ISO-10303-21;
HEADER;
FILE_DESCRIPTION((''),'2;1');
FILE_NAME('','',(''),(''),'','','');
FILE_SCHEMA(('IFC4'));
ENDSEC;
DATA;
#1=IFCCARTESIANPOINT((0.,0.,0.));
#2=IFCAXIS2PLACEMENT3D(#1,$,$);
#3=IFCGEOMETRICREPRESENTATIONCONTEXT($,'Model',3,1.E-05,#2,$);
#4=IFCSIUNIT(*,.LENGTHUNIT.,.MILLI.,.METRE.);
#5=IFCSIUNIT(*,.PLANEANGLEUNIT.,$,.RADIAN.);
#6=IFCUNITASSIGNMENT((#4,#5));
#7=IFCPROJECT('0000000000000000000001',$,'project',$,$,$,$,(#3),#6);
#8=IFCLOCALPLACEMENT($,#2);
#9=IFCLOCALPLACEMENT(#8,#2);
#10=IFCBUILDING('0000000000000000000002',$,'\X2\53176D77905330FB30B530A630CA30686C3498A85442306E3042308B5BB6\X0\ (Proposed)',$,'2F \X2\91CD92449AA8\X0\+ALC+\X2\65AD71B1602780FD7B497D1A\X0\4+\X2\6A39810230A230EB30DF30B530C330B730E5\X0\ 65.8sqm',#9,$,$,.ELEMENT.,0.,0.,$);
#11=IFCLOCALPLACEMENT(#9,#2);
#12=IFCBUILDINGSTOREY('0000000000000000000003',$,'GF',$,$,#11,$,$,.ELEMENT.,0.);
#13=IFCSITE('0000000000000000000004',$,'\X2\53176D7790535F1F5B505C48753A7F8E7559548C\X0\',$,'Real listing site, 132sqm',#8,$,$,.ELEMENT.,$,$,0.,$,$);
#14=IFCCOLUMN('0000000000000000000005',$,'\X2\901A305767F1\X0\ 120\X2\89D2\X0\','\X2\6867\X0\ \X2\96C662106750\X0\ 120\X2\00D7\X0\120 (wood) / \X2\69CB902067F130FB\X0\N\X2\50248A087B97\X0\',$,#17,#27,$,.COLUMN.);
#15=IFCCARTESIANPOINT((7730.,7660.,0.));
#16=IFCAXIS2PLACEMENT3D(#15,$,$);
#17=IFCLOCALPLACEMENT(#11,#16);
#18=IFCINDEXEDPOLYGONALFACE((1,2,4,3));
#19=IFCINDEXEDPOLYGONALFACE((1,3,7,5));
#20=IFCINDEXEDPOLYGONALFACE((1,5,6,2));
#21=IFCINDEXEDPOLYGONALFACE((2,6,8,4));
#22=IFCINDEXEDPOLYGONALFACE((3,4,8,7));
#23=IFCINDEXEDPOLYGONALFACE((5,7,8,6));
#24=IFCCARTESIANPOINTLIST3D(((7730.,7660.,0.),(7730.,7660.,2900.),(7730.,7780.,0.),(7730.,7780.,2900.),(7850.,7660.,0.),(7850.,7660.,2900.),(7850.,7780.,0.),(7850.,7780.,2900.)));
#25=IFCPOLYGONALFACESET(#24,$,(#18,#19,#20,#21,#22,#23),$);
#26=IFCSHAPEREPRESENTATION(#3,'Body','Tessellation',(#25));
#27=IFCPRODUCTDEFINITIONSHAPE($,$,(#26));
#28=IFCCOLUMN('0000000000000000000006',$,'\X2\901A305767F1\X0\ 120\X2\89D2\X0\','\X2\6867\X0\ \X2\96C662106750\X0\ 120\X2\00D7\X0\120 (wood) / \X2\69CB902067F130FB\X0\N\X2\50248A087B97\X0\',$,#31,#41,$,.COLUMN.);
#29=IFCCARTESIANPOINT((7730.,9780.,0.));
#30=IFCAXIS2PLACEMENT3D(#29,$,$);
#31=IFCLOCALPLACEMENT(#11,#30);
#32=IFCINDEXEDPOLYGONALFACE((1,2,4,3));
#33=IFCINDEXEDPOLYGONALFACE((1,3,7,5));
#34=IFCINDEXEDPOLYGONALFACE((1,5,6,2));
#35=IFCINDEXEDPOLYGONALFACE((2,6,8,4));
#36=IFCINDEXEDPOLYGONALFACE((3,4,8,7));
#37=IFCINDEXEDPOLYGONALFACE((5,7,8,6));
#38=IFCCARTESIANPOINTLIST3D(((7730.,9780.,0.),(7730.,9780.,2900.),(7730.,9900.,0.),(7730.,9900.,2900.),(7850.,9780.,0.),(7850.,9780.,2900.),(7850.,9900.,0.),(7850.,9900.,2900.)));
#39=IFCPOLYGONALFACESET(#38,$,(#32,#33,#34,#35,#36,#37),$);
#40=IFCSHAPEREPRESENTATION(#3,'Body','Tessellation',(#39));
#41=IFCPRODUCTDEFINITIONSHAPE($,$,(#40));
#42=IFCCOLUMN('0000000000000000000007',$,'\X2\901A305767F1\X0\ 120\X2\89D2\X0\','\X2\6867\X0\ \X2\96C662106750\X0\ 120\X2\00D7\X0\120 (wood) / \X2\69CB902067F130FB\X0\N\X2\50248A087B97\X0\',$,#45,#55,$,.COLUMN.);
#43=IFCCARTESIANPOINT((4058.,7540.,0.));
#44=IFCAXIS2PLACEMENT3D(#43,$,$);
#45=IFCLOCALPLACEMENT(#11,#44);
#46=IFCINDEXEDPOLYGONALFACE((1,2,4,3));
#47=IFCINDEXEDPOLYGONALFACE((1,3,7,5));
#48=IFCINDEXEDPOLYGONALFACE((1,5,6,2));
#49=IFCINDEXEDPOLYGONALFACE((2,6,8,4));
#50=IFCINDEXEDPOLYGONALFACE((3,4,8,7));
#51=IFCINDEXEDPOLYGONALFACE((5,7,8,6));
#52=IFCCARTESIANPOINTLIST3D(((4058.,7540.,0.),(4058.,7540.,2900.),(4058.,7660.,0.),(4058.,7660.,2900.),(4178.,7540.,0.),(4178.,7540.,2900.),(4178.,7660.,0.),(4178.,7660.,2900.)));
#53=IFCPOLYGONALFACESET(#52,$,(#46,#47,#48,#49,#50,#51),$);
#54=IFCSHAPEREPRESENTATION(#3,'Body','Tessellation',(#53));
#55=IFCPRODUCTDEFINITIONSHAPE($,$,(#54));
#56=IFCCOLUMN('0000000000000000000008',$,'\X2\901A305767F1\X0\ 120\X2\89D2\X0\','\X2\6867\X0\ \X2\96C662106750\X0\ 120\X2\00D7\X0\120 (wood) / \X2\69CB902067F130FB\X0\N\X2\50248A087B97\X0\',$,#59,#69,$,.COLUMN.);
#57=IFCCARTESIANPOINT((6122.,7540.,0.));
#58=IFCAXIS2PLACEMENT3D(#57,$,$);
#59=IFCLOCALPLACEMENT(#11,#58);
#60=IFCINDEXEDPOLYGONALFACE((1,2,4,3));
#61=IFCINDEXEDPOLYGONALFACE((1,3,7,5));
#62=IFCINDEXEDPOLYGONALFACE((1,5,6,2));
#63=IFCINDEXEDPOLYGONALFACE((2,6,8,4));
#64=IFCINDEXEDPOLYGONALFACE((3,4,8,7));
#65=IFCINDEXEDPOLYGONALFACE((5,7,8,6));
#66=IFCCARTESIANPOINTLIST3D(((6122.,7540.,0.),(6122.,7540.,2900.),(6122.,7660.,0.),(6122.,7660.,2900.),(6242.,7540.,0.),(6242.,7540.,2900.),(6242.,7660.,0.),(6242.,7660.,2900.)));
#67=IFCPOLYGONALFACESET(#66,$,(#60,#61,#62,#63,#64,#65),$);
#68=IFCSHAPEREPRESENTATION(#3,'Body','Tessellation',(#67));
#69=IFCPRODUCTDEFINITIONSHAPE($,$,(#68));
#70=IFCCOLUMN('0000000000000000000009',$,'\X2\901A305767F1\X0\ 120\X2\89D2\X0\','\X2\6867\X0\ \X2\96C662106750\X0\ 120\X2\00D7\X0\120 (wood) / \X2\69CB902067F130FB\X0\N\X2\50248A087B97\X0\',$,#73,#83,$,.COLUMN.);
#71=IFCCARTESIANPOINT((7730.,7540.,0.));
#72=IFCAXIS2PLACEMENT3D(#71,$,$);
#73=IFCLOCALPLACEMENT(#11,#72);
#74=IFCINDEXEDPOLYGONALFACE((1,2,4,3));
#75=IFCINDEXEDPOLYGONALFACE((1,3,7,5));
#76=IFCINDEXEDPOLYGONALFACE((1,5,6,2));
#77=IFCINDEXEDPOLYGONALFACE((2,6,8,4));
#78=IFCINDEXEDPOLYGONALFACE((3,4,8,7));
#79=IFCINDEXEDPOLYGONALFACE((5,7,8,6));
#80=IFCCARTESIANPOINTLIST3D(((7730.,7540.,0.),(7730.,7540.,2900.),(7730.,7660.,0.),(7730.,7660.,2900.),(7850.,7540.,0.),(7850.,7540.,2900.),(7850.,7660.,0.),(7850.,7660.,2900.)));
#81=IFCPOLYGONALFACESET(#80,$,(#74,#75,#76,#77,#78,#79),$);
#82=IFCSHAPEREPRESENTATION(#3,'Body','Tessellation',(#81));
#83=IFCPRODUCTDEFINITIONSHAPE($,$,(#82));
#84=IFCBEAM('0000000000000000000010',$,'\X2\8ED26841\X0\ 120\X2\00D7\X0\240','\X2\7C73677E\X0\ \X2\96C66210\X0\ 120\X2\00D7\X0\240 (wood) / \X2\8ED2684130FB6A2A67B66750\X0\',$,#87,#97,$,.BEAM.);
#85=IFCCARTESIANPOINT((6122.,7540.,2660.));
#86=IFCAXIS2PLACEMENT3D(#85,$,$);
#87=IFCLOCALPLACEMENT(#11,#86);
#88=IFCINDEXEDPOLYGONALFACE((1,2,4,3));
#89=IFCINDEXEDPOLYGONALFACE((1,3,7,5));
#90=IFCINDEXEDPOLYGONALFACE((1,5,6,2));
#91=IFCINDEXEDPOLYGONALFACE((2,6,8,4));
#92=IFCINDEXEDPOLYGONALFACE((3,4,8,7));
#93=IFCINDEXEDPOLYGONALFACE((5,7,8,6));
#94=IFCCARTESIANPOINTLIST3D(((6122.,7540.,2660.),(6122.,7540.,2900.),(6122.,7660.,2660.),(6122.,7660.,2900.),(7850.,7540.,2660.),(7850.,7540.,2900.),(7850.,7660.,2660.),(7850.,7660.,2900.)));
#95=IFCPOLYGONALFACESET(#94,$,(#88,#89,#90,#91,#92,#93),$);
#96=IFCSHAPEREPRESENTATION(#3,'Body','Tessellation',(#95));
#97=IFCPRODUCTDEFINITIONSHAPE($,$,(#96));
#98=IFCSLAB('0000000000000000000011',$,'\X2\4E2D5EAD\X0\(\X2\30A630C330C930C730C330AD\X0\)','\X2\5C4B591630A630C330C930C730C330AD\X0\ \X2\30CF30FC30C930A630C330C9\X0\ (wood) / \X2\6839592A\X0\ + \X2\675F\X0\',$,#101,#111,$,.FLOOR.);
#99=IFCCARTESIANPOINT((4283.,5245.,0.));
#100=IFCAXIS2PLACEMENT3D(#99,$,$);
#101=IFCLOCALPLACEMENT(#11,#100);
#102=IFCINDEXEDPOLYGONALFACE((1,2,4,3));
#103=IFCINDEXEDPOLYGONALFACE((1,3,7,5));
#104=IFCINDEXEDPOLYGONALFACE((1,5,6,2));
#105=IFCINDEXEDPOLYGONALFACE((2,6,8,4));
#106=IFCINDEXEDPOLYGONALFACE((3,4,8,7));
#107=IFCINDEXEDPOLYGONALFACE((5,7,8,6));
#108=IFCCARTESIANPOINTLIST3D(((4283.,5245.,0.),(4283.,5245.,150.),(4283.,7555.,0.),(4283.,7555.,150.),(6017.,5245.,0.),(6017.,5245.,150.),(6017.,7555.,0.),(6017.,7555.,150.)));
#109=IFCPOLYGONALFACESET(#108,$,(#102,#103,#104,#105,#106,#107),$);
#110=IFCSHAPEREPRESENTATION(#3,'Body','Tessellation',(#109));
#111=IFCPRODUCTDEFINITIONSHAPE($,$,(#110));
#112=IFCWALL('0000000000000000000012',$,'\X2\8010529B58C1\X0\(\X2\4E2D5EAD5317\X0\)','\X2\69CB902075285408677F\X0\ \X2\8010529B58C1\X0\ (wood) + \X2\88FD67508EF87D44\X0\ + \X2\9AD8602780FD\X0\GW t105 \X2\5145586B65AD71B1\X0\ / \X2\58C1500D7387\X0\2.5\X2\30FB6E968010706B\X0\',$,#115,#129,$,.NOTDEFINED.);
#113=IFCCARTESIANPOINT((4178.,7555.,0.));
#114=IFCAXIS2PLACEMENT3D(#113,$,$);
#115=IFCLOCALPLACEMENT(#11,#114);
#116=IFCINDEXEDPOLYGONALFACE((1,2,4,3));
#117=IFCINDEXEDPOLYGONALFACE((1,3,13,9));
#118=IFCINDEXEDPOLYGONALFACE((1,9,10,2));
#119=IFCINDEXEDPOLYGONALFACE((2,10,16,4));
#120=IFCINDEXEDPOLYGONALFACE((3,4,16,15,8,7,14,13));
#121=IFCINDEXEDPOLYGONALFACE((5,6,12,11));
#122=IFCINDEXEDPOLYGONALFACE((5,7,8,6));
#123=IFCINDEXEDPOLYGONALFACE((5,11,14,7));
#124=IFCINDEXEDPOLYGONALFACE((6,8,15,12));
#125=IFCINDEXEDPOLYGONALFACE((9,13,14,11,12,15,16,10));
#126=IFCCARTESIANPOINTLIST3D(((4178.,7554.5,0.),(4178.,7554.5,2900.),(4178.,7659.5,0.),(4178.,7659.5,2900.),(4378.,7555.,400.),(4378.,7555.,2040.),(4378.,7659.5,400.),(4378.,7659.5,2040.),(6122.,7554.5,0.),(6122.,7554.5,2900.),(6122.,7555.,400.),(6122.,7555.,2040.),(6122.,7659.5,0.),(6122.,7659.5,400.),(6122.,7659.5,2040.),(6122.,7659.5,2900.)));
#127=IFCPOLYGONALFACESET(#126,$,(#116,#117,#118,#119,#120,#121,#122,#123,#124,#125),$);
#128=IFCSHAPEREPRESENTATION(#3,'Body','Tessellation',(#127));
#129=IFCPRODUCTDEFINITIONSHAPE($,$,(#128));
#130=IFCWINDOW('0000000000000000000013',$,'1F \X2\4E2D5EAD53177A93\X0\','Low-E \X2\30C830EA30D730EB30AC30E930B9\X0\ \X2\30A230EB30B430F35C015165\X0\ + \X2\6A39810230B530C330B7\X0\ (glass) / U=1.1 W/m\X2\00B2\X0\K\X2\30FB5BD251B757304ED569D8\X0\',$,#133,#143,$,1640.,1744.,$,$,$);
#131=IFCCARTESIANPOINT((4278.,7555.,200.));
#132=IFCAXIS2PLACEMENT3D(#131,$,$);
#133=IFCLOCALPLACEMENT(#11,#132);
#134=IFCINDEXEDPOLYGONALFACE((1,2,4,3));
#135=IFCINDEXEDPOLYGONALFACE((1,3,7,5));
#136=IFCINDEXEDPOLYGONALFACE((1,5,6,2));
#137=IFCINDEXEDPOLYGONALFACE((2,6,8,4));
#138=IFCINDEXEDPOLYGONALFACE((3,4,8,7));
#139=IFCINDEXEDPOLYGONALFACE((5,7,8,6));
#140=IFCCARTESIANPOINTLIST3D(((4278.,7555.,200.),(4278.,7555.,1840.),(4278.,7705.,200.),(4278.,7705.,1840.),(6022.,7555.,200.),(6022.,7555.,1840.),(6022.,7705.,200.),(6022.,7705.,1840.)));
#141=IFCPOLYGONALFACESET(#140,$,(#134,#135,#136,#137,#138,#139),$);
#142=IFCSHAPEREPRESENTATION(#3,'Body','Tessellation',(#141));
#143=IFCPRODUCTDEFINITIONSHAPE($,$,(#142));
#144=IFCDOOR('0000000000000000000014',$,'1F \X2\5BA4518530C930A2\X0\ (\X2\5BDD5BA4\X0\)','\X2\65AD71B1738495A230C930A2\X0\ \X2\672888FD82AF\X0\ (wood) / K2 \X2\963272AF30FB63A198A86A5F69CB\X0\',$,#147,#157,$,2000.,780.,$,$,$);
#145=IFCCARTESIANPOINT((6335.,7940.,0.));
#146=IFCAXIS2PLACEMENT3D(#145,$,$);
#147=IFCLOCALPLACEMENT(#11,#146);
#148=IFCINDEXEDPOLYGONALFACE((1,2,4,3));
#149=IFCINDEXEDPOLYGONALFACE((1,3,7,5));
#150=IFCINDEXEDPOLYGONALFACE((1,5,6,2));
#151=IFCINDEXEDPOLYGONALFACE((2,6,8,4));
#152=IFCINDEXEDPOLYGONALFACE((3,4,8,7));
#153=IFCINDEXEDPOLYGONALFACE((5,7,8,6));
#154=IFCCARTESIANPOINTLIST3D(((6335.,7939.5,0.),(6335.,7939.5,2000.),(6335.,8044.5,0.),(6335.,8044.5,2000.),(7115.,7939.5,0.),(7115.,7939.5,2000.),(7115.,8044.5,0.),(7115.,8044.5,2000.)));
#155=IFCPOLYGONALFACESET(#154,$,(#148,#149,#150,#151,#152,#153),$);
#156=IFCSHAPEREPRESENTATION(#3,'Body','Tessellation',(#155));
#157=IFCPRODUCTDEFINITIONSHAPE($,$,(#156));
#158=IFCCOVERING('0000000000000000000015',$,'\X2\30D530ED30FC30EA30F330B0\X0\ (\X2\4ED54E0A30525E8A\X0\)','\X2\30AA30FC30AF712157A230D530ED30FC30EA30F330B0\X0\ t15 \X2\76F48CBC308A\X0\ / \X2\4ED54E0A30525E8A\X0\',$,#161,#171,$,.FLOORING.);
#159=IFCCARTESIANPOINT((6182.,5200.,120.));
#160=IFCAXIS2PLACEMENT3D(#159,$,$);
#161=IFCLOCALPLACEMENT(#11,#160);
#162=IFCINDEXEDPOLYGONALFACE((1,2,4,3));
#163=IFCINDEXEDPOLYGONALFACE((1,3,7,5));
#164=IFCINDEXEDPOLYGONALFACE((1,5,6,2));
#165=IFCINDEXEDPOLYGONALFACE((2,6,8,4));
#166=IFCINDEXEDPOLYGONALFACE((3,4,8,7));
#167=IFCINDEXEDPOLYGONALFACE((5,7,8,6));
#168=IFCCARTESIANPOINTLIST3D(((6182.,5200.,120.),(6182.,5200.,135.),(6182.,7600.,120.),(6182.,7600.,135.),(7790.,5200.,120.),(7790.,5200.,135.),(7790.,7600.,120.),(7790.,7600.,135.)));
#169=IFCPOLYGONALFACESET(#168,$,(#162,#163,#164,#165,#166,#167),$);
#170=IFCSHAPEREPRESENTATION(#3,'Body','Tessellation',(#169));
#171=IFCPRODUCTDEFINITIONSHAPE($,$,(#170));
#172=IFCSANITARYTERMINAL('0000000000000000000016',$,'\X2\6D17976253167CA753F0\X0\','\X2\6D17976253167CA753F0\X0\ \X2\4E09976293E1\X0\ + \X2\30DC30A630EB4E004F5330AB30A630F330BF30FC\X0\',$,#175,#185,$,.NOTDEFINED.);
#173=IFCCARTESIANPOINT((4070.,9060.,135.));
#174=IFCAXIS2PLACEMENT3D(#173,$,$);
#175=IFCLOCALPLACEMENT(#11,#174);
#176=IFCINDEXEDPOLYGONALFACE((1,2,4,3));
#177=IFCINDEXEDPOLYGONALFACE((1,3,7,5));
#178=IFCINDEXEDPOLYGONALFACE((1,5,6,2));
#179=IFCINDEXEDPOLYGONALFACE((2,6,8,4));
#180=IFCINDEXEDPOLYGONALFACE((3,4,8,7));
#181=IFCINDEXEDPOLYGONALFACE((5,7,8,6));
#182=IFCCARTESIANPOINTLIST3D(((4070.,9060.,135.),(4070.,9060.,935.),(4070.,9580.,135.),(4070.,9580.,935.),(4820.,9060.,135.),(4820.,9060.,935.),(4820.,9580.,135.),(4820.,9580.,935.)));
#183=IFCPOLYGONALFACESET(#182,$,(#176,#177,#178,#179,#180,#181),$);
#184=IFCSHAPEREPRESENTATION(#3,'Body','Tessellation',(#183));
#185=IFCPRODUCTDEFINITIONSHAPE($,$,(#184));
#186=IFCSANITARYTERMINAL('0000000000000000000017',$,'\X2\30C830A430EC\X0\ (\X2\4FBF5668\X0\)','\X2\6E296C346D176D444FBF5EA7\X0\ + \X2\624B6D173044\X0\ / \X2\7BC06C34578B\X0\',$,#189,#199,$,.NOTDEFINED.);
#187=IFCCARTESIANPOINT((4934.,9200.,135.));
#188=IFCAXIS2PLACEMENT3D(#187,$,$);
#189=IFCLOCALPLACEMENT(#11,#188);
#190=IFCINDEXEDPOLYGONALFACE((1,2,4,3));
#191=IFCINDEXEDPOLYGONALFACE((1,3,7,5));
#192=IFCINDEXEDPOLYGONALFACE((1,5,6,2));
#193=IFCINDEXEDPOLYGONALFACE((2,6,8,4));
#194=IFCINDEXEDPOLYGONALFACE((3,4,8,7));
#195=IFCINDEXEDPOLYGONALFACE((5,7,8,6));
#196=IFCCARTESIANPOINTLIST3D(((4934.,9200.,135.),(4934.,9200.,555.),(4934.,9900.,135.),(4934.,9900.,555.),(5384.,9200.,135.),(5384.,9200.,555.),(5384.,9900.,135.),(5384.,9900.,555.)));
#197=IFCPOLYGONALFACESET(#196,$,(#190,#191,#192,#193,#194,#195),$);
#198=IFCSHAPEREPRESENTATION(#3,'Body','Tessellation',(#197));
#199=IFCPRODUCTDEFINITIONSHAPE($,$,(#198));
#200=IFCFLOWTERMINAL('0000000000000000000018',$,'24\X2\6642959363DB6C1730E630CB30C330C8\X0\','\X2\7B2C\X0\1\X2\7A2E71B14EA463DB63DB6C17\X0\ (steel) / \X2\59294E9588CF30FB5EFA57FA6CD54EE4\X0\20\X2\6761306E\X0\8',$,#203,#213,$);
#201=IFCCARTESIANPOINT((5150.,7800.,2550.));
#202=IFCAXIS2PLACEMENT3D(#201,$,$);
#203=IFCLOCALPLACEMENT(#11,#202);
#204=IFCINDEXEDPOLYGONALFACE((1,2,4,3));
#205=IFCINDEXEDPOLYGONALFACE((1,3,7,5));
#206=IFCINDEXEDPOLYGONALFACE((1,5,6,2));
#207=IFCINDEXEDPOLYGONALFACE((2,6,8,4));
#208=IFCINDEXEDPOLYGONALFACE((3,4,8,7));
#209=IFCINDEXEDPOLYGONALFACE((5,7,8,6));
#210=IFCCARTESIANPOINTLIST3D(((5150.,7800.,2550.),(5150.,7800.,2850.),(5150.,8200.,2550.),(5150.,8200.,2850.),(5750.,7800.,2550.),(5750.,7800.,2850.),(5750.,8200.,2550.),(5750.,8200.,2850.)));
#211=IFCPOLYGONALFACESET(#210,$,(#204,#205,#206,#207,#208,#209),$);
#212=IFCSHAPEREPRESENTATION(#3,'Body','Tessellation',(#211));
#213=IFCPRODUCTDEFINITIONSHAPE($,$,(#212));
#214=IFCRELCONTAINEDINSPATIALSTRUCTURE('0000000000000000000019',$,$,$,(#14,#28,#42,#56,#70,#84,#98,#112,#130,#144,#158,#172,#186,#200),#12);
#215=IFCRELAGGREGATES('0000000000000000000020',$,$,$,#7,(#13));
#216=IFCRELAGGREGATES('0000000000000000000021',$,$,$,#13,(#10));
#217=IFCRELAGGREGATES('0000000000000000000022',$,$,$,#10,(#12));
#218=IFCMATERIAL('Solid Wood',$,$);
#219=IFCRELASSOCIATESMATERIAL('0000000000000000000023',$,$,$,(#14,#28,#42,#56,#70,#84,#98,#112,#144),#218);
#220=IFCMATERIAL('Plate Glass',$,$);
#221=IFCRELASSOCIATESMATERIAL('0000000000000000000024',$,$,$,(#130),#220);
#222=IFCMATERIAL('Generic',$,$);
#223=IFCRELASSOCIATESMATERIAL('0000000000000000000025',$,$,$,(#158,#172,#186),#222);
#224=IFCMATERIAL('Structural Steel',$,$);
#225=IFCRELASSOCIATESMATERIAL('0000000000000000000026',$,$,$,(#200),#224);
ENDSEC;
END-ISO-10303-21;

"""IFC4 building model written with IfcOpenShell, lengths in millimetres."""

from ifc_helpers import new_model, si_unit, frame, frame_2d, origin, place, context, project, spatial, rectangle, extrude, material, element, fill, save


model = new_model("IFC4")

# Units and contexts
model_context = context("Model", 3, precision=1e-05, world=origin())
ifc_project = project(units=[si_unit("LENGTHUNIT", "METRE", prefix="MILLI"), si_unit("PLANEANGLEUNIT", "RADIAN")], contexts=[model_context])

# Site, building, storey
site_placement = place(None, origin())
site = spatial("IfcSite", under=ifc_project, at=site_placement, Name="北海道弟子屈町美留和", ObjectType="Real listing site, 132sqm", CompositionType="ELEMENT", RefElevation=0.0)
building_placement = place(site_placement, origin())
building = spatial("IfcBuilding", under=site, at=building_placement, Name="北海道・サウナと水風呂のある家 (Proposed)", ObjectType="2F 重鉄骨+ALC+断熱性能等級4+樹脂アルミサッシュ 65.8sqm", CompositionType="ELEMENT", ElevationOfRefHeight=0.0, ElevationOfTerrain=0.0)
storey_placement = place(building_placement, origin())
storey = spatial("IfcBuildingStorey", under=building, at=storey_placement, Name="GF", CompositionType="ELEMENT", Elevation=0.0)

# Columns
ifc_material_1 = material(Name="Solid Wood")
column_1_placement = place(storey_placement, frame((7730.0, 7660.0, 0.0)))
element("IfcColumn", 1, at=column_1_placement, inside=storey, material=ifc_material_1, Name="通し柱 120角", Description="桧 集成材 120×120 (wood) / 構造柱・N値計算", PredefinedType="COLUMN", context=model_context, shape_type="SweptSolid", body=[
    extrude(rectangle(XDim=120.0, YDim=120.0, at=frame_2d((60.0, 60.0))), frame((7730.0, 7660.0, 0.0)), (0.0, 0.0, 1.0), 2900.0),
])
column_2_placement = place(storey_placement, frame((7730.0, 9780.0, 0.0)))
element("IfcColumn", 2, at=column_2_placement, inside=storey, material=ifc_material_1, Name="通し柱 120角", Description="桧 集成材 120×120 (wood) / 構造柱・N値計算", PredefinedType="COLUMN", context=model_context, shape_type="SweptSolid", body=[
    extrude(rectangle(XDim=120.0, YDim=120.0, at=frame_2d((60.0, 60.0))), frame((7730.0, 9780.0, 0.0)), (0.0, 0.0, 1.0), 2900.0),
])
column_3_placement = place(storey_placement, frame((4058.0, 7540.0, 0.0)))
element("IfcColumn", 3, at=column_3_placement, inside=storey, material=ifc_material_1, Name="通し柱 120角", Description="桧 集成材 120×120 (wood) / 構造柱・N値計算", PredefinedType="COLUMN", context=model_context, shape_type="SweptSolid", body=[
    extrude(rectangle(XDim=120.0, YDim=120.0, at=frame_2d((60.0, 60.0))), frame((4058.0, 7540.0, 0.0)), (0.0, 0.0, 1.0), 2900.0),
])
column_4_placement = place(storey_placement, frame((6122.0, 7540.0, 0.0)))
element("IfcColumn", 4, at=column_4_placement, inside=storey, material=ifc_material_1, Name="通し柱 120角", Description="桧 集成材 120×120 (wood) / 構造柱・N値計算", PredefinedType="COLUMN", context=model_context, shape_type="SweptSolid", body=[
    extrude(rectangle(XDim=120.0, YDim=120.0, at=frame_2d((60.0, 60.0))), frame((6122.0, 7540.0, 0.0)), (0.0, 0.0, 1.0), 2900.0),
])
column_5_placement = place(storey_placement, frame((7730.0, 7540.0, 0.0)))
element("IfcColumn", 5, at=column_5_placement, inside=storey, material=ifc_material_1, Name="通し柱 120角", Description="桧 集成材 120×120 (wood) / 構造柱・N値計算", PredefinedType="COLUMN", context=model_context, shape_type="SweptSolid", body=[
    extrude(rectangle(XDim=120.0, YDim=120.0, at=frame_2d((60.0, 60.0))), frame((7730.0, 7540.0, 0.0)), (0.0, 0.0, 1.0), 2900.0),
])

# Beam
beam_1_placement = place(storey_placement, frame((6122.0, 7540.0, 2660.0)))
element("IfcBeam", 6, at=beam_1_placement, inside=storey, material=ifc_material_1, Name="軒桁 120×240", Description="米松 集成 120×240 (wood) / 軒桁・横架材", PredefinedType="BEAM", context=model_context, shape_type="SweptSolid", body=[
    extrude(rectangle(XDim=1728.0, YDim=120.0, at=frame_2d((864.0, 60.0))), frame((6122.0, 7540.0, 2660.0)), (0.0, 0.0, 1.0), 240.0),
])

# Slab
slab_placement = place(storey_placement, frame((4283.0, 5245.0, 0.0)))
element("IfcSlab", 7, at=slab_placement, inside=storey, material=ifc_material_1, Name="中庭(ウッドデッキ)", Description="屋外ウッドデッキ ハードウッド (wood) / 根太 + 束", PredefinedType="FLOOR", context=model_context, shape_type="SweptSolid", body=[
    extrude(rectangle(XDim=1734.0, YDim=2310.0, at=frame_2d((867.0, 1155.0))), frame((4283.0, 5245.0, 0.0)), (0.0, 0.0, 1.0), 150.0),
])

# Wall, opening, window
wall_1_placement = place(storey_placement, frame((4178.0, 7555.0, 0.0)))
wall_1 = element("IfcWall", 8, at=wall_1_placement, inside=storey, material=ifc_material_1, Name="耐力壁(中庭北)", Description="構造用合板 耐力壁 (wood) + 製材軸組 + 高性能GW t105 充填断熱 / 壁倍率2.5・準耐火", PredefinedType="NOTDEFINED", context=model_context, shape_type="SweptSolid", body=[
    extrude(rectangle(XDim=1944.0, YDim=105.0, at=frame_2d((972.0, 52.0))), frame((4178.0, 7555.0, 0.0)), (0.0, 0.0, 1.0), 2900.0),
])
opening_placement = place(storey_placement, frame((4278.0, 7555.0, 200.0)))
opening = element("IfcOpeningElement", 9, at=opening_placement, cuts=wall_1, PredefinedType="NOTDEFINED", context=model_context, shape_type="SweptSolid", body=[
    extrude(rectangle(XDim=1744.0, YDim=150.0, at=frame_2d((872.0, 75.0))), frame((4278.0, 7555.0, 200.0)), (0.0, 0.0, 1.0), 1640.0),
])
ifc_material_2 = material(Name="Plate Glass")
window_placement = place(storey_placement, frame((4278.0, 7555.0, 200.0)))
window = element("IfcWindow", 10, at=window_placement, inside=storey, material=ifc_material_2, Name="1F 中庭北窓", Description="Low-E トリプルガラス アルゴン封入 + 樹脂サッシ (glass) / U=1.1 W/m²K・寒冷地仕様", OverallHeight=1640.0, OverallWidth=1744.0, context=model_context, shape_type="SweptSolid", body=[
    extrude(rectangle(XDim=1744.0, YDim=150.0, at=frame_2d((872.0, 75.0))), frame((4278.0, 7555.0, 200.0)), (0.0, 0.0, 1.0), 1640.0),
])
fill(opening, window)

# Door
door_placement = place(storey_placement, frame((6335.0, 7940.0, 0.0)))
element("IfcDoor", 11, at=door_placement, inside=storey, material=ifc_material_1, Name="1F 室内ドア (寝室)", Description="断熱玄関ドア 木製芯 (wood) / K2 防犯・採風機構", OverallHeight=2000.0, OverallWidth=780.0, context=model_context, shape_type="SweptSolid", body=[
    extrude(rectangle(XDim=780.0, YDim=105.0, at=frame_2d((390.0, 52.0))), frame((6335.0, 7940.0, 0.0)), (0.0, 0.0, 1.0), 2000.0),
])

# Covering
ifc_material_3 = material(Name="Generic")
covering_placement = place(storey_placement, frame((6182.0, 5200.0, 120.0)))
element("IfcCovering", 12, at=covering_placement, inside=storey, material=ifc_material_3, Name="フローリング (仕上げ床)", Description="オーク無垢フローリング t15 直貼り / 仕上げ床", PredefinedType="FLOORING", context=model_context, shape_type="SweptSolid", body=[
    extrude(rectangle(XDim=1608.0, YDim=2400.0, at=frame_2d((804.0, 1200.0))), frame((6182.0, 5200.0, 120.0)), (0.0, 0.0, 1.0), 15.0),
])

# Sanitary terminals
sanitary_terminal_1_placement = place(storey_placement, frame((4070.0, 9060.0, 135.0)))
element("IfcSanitaryTerminal", 13, at=sanitary_terminal_1_placement, inside=storey, material=ifc_material_3, Name="洗面化粧台", Description="洗面化粧台 三面鏡 + ボウル一体カウンター", PredefinedType="NOTDEFINED", context=model_context, shape_type="SweptSolid", body=[
    extrude(rectangle(XDim=750.0, YDim=520.0, at=frame_2d((375.0, 260.0))), frame((4070.0, 9060.0, 135.0)), (0.0, 0.0, 1.0), 800.0),
])
sanitary_terminal_2_placement = place(storey_placement, frame((4934.0, 9200.0, 135.0)))
element("IfcSanitaryTerminal", 14, at=sanitary_terminal_2_placement, inside=storey, material=ifc_material_3, Name="トイレ (便器)", Description="温水洗浄便座 + 手洗い / 節水型", PredefinedType="NOTDEFINED", context=model_context, shape_type="SweptSolid", body=[
    extrude(rectangle(XDim=450.0, YDim=700.0, at=frame_2d((225.0, 350.0))), frame((4934.0, 9200.0, 135.0)), (0.0, 0.0, 1.0), 420.0),
])

# Flow terminal
ifc_material_4 = material(Name="Structural Steel")
flow_terminal_placement = place(storey_placement, frame((5150.0, 7800.0, 2550.0)))
element("IfcFlowTerminal", 15, at=flow_terminal_placement, inside=storey, material=ifc_material_4, Name="24時間換気ユニット", Description="第1種熱交換換気 (steel) / 天井裏・建基法令20条の8", context=model_context, shape_type="SweptSolid", body=[
    extrude(rectangle(XDim=600.0, YDim=400.0, at=frame_2d((300.0, 200.0))), frame((5150.0, 7800.0, 2550.0)), (0.0, 0.0, 1.0), 300.0),
])

save(model, "model.ifc")
